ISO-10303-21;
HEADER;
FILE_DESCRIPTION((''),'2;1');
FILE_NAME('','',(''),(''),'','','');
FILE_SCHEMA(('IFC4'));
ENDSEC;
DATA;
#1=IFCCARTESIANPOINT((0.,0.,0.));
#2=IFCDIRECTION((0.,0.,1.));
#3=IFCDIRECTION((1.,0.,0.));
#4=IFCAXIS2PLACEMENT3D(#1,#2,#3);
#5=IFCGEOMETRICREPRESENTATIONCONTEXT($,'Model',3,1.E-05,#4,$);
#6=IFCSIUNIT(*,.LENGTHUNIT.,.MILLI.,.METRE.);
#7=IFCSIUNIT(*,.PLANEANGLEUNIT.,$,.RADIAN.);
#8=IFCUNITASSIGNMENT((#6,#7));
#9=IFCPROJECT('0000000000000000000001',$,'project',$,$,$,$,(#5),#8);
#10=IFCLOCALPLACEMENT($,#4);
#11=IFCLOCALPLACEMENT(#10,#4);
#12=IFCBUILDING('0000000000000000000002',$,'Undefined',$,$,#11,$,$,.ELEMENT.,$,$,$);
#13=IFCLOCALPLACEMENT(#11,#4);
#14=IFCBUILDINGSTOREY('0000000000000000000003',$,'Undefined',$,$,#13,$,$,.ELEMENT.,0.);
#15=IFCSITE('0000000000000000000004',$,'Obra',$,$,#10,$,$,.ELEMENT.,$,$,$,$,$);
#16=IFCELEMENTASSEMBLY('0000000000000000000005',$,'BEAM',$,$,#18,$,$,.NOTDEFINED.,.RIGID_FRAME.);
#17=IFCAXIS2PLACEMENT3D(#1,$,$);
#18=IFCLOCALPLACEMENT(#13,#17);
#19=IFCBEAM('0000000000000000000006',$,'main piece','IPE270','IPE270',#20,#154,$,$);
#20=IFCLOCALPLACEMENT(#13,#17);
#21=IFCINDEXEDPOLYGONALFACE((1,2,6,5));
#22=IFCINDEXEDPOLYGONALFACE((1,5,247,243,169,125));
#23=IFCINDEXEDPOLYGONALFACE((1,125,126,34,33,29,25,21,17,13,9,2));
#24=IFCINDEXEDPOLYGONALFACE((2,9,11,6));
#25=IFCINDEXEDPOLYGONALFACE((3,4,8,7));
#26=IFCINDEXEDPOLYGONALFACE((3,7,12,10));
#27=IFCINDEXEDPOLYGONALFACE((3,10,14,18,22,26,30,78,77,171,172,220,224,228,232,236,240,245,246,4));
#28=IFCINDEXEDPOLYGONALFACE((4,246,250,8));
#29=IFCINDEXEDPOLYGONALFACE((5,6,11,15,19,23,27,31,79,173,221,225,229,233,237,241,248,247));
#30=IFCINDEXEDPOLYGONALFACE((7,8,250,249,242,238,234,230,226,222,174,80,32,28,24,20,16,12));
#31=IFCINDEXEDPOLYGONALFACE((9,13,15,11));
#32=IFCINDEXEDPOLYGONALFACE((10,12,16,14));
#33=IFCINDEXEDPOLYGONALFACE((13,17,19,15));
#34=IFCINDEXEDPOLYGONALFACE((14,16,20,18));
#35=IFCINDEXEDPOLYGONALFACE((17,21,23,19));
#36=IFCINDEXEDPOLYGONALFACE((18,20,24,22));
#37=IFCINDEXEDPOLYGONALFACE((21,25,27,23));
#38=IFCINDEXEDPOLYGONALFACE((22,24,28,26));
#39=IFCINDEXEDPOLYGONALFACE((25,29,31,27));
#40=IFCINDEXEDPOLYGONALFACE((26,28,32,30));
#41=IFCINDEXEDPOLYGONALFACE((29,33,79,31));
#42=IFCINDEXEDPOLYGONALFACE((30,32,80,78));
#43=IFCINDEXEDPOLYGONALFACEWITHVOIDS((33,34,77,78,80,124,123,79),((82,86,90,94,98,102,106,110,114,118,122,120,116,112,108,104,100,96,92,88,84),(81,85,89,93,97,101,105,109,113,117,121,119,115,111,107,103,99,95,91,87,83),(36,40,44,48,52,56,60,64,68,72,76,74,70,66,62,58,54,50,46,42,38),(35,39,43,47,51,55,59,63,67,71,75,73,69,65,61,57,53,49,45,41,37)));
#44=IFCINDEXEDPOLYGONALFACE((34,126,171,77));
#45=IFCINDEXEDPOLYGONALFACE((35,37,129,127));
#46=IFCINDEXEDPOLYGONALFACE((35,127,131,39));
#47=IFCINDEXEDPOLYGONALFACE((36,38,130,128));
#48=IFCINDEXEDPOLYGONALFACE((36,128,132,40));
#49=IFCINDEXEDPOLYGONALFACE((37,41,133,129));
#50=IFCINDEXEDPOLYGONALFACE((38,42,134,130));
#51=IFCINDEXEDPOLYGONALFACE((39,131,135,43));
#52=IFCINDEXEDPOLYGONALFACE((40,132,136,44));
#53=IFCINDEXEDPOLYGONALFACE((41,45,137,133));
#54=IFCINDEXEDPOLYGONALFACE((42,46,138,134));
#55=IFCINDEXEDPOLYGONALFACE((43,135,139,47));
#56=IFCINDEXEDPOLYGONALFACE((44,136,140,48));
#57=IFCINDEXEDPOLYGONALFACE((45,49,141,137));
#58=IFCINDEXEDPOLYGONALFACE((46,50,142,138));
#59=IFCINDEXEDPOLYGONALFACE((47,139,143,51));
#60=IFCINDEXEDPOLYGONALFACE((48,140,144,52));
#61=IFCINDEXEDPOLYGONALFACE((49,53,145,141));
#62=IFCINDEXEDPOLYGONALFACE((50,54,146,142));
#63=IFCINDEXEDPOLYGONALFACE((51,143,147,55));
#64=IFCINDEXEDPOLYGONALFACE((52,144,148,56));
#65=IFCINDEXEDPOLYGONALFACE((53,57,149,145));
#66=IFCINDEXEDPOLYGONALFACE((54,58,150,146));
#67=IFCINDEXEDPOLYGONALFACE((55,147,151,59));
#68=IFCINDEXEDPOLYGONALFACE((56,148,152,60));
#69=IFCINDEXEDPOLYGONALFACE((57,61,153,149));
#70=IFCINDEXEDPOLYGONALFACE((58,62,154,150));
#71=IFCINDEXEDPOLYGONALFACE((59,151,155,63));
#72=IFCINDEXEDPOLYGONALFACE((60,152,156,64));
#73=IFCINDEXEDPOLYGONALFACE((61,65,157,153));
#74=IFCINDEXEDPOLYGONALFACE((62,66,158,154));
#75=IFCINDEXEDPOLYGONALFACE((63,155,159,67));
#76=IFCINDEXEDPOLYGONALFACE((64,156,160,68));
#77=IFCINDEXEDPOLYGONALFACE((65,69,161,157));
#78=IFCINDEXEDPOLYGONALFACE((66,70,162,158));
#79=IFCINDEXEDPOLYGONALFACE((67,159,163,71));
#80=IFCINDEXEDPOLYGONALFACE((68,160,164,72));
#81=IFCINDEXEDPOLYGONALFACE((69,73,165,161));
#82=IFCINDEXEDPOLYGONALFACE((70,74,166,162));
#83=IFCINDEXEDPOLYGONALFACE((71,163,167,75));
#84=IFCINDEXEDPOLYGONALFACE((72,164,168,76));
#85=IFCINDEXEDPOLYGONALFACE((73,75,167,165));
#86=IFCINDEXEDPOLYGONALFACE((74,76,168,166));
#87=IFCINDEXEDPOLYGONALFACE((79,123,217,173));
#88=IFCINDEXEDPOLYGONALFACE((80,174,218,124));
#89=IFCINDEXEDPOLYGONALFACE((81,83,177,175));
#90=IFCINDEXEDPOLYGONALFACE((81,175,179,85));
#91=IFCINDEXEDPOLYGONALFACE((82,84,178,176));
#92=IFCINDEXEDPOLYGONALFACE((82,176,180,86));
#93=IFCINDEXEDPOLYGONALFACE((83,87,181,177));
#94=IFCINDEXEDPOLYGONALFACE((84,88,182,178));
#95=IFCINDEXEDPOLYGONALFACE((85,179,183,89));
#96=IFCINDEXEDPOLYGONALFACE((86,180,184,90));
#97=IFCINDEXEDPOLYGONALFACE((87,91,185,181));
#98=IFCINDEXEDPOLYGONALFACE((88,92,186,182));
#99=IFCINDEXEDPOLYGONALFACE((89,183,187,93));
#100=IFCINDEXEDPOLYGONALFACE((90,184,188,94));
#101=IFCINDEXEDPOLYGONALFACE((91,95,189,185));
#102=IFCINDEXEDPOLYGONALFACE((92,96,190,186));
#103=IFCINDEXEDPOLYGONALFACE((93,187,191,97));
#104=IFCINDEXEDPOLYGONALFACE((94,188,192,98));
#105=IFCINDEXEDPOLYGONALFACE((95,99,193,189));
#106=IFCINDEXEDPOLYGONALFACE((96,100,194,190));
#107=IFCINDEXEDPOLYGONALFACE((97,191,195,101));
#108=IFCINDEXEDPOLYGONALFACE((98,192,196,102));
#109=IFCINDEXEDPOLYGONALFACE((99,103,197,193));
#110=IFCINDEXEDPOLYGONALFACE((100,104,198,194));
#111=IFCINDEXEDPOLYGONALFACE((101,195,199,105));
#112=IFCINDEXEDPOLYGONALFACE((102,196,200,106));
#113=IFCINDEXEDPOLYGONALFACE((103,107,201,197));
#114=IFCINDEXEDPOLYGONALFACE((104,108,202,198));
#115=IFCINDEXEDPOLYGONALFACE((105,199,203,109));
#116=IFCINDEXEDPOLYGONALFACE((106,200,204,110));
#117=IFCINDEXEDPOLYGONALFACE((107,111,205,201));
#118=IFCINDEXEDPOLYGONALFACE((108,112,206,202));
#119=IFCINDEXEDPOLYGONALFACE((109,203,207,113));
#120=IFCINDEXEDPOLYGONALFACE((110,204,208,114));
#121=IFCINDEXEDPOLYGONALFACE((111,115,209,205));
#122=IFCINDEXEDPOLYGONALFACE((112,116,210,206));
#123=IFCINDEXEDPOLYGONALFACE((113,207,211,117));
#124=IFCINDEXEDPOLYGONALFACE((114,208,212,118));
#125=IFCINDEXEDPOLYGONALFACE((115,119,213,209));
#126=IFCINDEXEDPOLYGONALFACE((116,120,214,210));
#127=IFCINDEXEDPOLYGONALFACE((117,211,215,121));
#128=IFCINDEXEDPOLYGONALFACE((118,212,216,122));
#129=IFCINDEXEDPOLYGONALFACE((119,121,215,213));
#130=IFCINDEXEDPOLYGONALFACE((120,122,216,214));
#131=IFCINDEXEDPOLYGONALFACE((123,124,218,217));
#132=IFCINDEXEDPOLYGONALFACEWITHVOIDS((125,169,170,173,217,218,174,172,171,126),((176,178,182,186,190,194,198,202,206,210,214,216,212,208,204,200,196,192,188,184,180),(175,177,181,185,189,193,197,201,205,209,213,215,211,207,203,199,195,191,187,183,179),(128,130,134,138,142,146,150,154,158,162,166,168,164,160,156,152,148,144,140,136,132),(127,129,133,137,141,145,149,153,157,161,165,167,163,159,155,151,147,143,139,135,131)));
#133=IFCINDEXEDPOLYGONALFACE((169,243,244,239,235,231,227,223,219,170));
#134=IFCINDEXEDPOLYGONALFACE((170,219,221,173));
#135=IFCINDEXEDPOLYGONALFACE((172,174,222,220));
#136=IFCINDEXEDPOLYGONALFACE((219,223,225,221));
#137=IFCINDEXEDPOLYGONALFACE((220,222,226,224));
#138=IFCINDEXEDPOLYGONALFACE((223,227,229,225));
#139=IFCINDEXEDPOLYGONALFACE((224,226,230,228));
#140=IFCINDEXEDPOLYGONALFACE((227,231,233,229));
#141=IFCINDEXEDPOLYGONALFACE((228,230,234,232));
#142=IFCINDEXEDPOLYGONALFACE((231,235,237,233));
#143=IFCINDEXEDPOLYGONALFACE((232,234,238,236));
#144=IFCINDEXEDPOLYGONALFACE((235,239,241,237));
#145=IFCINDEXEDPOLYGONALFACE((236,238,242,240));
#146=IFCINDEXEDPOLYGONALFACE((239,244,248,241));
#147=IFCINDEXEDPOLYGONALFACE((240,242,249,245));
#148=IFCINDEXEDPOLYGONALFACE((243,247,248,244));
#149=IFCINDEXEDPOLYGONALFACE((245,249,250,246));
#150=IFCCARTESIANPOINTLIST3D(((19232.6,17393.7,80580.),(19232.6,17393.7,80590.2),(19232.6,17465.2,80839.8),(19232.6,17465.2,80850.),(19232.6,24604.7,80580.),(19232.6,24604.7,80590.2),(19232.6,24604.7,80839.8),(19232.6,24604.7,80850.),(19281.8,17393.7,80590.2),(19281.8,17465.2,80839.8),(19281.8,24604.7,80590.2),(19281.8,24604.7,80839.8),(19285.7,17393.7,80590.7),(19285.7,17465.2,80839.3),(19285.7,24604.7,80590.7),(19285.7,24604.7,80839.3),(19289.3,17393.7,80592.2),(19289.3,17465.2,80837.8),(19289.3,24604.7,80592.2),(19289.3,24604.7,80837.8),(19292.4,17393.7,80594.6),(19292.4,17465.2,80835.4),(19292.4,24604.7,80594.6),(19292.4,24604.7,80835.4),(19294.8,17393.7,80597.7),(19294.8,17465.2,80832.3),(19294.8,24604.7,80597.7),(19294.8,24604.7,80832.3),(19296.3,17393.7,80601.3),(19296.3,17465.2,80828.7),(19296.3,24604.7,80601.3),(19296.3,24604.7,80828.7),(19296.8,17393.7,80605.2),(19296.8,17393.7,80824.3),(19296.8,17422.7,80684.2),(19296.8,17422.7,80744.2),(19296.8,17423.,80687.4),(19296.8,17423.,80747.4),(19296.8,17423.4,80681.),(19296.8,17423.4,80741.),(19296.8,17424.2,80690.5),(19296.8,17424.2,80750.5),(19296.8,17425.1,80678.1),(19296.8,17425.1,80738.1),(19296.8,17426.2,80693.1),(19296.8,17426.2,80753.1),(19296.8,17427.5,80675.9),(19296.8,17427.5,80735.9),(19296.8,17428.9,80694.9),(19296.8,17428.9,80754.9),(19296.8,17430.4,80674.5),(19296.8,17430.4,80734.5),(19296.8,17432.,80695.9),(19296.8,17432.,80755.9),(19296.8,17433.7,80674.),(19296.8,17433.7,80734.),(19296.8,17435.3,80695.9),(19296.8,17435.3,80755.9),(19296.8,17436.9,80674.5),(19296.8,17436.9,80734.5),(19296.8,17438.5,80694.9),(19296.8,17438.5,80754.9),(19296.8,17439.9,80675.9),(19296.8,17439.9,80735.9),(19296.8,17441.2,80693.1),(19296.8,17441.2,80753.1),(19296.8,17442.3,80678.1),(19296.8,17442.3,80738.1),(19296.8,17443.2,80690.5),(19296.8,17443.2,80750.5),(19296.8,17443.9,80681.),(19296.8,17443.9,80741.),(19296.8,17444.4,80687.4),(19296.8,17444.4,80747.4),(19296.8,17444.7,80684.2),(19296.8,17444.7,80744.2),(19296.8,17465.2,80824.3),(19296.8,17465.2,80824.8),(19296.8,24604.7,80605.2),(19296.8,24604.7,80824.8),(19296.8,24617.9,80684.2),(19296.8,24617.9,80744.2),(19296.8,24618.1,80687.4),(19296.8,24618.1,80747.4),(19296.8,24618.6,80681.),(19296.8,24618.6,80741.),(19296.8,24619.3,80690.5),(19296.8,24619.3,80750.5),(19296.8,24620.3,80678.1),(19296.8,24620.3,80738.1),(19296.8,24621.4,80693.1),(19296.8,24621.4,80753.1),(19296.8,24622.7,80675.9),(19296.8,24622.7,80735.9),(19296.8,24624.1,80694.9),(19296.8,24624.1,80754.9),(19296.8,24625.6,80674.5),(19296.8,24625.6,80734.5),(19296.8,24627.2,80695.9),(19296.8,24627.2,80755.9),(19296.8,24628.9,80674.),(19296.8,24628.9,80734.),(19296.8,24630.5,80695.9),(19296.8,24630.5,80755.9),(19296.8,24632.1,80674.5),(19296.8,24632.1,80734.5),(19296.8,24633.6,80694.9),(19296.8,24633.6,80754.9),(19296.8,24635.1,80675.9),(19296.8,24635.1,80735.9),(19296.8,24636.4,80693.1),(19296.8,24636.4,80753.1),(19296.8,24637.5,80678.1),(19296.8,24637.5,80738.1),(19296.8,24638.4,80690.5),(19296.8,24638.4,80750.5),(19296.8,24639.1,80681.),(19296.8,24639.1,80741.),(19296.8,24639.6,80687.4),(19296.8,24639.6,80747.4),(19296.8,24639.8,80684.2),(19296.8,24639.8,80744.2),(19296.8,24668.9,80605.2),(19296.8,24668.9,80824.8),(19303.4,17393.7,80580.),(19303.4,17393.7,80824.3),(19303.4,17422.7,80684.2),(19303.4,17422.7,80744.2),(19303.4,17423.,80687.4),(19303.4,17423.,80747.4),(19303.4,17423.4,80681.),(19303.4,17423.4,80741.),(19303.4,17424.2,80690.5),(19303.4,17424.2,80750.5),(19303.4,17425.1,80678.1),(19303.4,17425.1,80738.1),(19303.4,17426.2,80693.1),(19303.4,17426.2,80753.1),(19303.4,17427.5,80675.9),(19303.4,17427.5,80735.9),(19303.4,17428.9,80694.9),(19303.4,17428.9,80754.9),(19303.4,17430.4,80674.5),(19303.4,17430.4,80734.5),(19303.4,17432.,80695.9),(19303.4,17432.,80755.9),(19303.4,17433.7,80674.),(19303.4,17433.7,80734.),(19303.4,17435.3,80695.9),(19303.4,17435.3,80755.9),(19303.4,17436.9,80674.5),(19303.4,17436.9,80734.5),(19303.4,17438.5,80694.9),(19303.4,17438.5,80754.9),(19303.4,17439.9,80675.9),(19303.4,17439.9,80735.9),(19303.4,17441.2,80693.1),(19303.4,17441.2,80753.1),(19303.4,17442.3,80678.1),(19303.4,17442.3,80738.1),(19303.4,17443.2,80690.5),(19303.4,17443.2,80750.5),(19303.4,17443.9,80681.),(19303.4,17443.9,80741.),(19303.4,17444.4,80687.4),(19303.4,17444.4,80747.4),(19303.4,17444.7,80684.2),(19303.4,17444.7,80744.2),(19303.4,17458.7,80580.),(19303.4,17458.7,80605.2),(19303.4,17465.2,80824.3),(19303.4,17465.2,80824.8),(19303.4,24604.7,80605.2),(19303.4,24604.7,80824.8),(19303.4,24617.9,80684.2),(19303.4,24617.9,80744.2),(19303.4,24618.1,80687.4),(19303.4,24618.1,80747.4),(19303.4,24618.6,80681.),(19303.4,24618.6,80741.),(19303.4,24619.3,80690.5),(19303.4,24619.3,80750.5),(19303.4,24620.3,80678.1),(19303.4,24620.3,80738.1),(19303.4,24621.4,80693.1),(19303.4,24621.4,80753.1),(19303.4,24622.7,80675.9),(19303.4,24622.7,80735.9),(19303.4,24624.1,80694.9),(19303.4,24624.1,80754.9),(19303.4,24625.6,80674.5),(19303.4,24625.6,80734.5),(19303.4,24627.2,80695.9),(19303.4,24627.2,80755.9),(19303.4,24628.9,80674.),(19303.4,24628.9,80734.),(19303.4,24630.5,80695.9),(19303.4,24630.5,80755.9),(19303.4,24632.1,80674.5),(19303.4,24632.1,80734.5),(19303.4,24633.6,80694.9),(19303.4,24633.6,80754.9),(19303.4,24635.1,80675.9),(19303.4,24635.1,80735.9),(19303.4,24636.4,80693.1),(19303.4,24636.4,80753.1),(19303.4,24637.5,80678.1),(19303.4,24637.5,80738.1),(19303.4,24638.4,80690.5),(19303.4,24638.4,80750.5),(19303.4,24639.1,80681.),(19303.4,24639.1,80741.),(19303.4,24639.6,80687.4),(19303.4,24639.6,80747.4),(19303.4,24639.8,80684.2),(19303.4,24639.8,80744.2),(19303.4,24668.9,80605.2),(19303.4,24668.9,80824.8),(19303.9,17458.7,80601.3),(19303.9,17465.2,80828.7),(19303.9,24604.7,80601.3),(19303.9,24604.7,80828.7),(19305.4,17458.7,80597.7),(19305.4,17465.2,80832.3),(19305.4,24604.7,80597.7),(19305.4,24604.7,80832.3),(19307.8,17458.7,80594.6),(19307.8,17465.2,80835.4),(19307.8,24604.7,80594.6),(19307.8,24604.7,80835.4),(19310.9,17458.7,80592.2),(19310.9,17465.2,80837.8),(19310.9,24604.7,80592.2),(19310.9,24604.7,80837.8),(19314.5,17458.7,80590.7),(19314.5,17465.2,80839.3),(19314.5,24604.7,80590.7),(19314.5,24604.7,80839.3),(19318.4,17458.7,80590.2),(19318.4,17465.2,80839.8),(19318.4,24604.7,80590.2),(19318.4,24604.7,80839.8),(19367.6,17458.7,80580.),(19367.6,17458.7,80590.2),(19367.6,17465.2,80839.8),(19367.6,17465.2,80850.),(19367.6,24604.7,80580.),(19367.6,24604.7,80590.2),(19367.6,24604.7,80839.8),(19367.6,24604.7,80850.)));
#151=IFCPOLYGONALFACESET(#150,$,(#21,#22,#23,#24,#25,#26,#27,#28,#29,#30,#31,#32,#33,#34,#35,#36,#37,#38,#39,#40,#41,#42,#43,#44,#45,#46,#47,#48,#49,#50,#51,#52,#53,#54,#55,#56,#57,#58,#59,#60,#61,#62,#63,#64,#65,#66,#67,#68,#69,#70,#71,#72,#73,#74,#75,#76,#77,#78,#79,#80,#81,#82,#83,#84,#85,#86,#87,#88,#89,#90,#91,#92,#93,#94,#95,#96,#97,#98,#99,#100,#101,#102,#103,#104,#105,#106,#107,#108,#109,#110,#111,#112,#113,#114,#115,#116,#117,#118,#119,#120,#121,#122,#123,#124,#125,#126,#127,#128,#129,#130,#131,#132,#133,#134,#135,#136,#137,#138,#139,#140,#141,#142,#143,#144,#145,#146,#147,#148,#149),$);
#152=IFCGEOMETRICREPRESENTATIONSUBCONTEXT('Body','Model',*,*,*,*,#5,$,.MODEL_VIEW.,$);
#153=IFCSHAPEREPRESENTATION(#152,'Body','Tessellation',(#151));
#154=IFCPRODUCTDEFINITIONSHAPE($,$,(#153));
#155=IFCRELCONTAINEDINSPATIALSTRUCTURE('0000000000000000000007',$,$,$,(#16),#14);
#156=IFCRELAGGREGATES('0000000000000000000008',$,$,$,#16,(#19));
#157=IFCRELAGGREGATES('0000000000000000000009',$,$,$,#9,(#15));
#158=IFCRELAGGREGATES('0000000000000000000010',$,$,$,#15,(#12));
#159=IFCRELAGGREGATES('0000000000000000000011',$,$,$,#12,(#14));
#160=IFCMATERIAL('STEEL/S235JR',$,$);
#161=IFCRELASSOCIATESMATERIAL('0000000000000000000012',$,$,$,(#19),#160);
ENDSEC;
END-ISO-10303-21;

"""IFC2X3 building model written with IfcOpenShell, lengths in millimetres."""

from ifc_helpers import new_model, si_unit, frame, origin_with_axes, origin_2d_with_axis, place, context, subcontext, project, spatial, rectangle, circle, i_section, extrude, clip, halfspace, source, transform, mapped, material, element, aggregate, save


model = new_model("IFC2X3")

# Units and contexts
model_context = context("Model", 3, precision=1e-05, world=origin_with_axes())
body_context = subcontext(model_context, "Body", "Model", "MODEL_VIEW")
ifc_project = project(units=[si_unit("LENGTHUNIT", "METRE", prefix="MILLI"), si_unit("PLANEANGLEUNIT", "RADIAN")], contexts=[model_context])

# Site, building, storey
site_placement = place(None, origin_with_axes())
site = spatial("IfcSite", under=ifc_project, at=site_placement, Name="Obra", CompositionType="ELEMENT")
building_placement = place(site_placement, origin_with_axes())
building = spatial("IfcBuilding", under=site, at=building_placement, Name="Undefined", CompositionType="ELEMENT")
storey_placement = place(building_placement, origin_with_axes())
storey = spatial("IfcBuildingStorey", under=building, at=storey_placement, Name="Undefined", CompositionType="ELEMENT", Elevation=0.0)

# Shared definitions
ifc_material = material(Name="STEEL/S235JR")

# Element assembly, beam, openings
assembly_1_placement = place(storey_placement, origin_with_axes())
assembly_1 = element("IfcElementAssembly", 1, at=assembly_1_placement, inside=storey, Name="BEAM", AssemblyPlace="NOTDEFINED", PredefinedType="RIGID_FRAME")
beam_1_placement = place(assembly_1_placement, frame((19300.1, 17475.1, 80715.0), z_axis=(0.0, 0.0, 1.0), x_axis=(0.0, 1.0, 0.0)))
beam_1 = element("IfcBeam", 2, at=beam_1_placement, material=ifc_material, Name="main piece", Description="IPE270", ObjectType="IPE270", context=body_context, shape_type="Clipping", body=[
    clip(clip(extrude(i_section(OverallWidth=135.0, OverallDepth=270.0, WebThickness=6.6, FlangeThickness=10.2, FilletRadius=15.0, at=origin_2d_with_axis()), frame((7193.7, 0.0, 0.0), z_axis=(-1.0, 0.0, 0.0), x_axis=(0.0, -1.0, 0.0)), (0.0, 0.0, 1.0), 7275.2), halfspace(frame((7193.7, 0.0, -235.0), z_axis=(-1.0, -0.000001, 0.0), x_axis=(-0.000001, 1.0, 0.0)), True)), halfspace(frame((-81.4, 0.0, -235.0), z_axis=(1.0, 0.0, 0.0), x_axis=(0.0, -1.0, 0.0)), True)),
])
opening_1_placement = place(assembly_1_placement, frame((19300.1, 17475.1, 80715.0), z_axis=(0.0, 0.0, 1.0), x_axis=(0.0, 1.0, 0.0)))
element("IfcOpeningElement", 3, at=opening_1_placement, cuts=beam_1, ObjectType="Recess", context=body_context, shape_type="SweptSolid", body=[
    extrude(rectangle(XDim=26.2, YDim=76.2, at=origin_2d_with_axis()), frame((7167.6, 68.5, -122.9), z_axis=(0.000001, -1.0, 0.0), x_axis=(0.0, 0.0, -1.0)), (0.0, 0.0, 1.0), 137.0),
])
opening_2_placement = place(assembly_1_placement, frame((19300.1, 17475.1, 80715.0), z_axis=(0.0, 0.0, 1.0), x_axis=(0.0, 1.0, 0.0)))
element("IfcOpeningElement", 4, at=opening_2_placement, cuts=beam_1, ObjectType="Recess", context=body_context, shape_type="SweptSolid", body=[
    extrude(rectangle(XDim=26.2, YDim=76.2, at=origin_2d_with_axis()), frame((7167.6, 68.5, 122.9), z_axis=(0.000001, -1.0, 0.0), x_axis=(0.0, 0.0, -1.0)), (0.0, 0.0, 1.0), 137.0),
])
opening_3_placement = place(assembly_1_placement, frame((19300.1, 17475.1, 80715.0), z_axis=(0.0, 0.0, 1.0), x_axis=(0.0, 1.0, 0.0)))
element("IfcOpeningElement", 5, at=opening_3_placement, cuts=beam_1, ObjectType="Recess", context=body_context, shape_type="SweptSolid", body=[
    extrude(rectangle(XDim=75.0, YDim=300.0, at=origin_2d_with_axis()), frame((-53.9, -153.3, 124.3), z_axis=(0.0, 0.0, -1.0), x_axis=(1.0, 0.0, 0.0)), (0.0, 0.0, 1.0), 278.6),
])
opening_4_placement = place(assembly_1_placement, frame((19300.1, 17475.1, 80715.0), z_axis=(0.0, 0.0, 1.0), x_axis=(0.0, 1.0, 0.0)))
element("IfcOpeningElement", 6, at=opening_4_placement, cuts=beam_1, ObjectType="Recess", context=body_context, shape_type="SweptSolid", body=[
    extrude(rectangle(XDim=26.7, YDim=83.5, at=origin_2d_with_axis()), frame((-51.7, -68.5, 122.7), z_axis=(0.0, 1.0, 0.0), x_axis=(0.0, 0.0, -1.0)), (0.0, 0.0, 1.0), 137.0),
])
shared_shape_1 = source(origin_with_axes(), body_context, "Body", "SweptSolid", [
    extrude(circle(Radius=11.0, at=origin_2d_with_axis()), frame((0.0, -3.4, 0.0), z_axis=(0.0, 1.0, 0.0), x_axis=(1.0, 0.0, 0.0)), (0.0, 0.0, 1.0), 6.8),
])
opening_5_placement = place(assembly_1_placement, frame((19300.1, 24668.9, 80850.0), z_axis=(0.000001, -1.0, 0.0), x_axis=(0.0, 0.0, -1.0)))
element("IfcOpeningElement", 7, at=opening_5_placement, cuts=beam_1, ObjectType="Opening", context=body_context, shape_type="MappedRepresentation", body=[
    mapped(shared_shape_1, transform((105.0, 0.0, 40.0))),
    mapped(shared_shape_1, transform((165.0, 0.0, 40.0))),
])
opening_6_placement = place(assembly_1_placement, frame((19300.1, 17393.7, 80850.0), z_axis=(0.0, 1.0, 0.0), x_axis=(0.0, 0.0, -1.0)))
element("IfcOpeningElement", 8, at=opening_6_placement, cuts=beam_1, ObjectType="Opening", context=body_context, shape_type="MappedRepresentation", body=[
    mapped(shared_shape_1, transform((105.0, 0.0, 40.0))),
    mapped(shared_shape_1, transform((165.0, 0.0, 40.0))),
])
aggregate(assembly_1, [beam_1])

save(model, "model.ifc")
